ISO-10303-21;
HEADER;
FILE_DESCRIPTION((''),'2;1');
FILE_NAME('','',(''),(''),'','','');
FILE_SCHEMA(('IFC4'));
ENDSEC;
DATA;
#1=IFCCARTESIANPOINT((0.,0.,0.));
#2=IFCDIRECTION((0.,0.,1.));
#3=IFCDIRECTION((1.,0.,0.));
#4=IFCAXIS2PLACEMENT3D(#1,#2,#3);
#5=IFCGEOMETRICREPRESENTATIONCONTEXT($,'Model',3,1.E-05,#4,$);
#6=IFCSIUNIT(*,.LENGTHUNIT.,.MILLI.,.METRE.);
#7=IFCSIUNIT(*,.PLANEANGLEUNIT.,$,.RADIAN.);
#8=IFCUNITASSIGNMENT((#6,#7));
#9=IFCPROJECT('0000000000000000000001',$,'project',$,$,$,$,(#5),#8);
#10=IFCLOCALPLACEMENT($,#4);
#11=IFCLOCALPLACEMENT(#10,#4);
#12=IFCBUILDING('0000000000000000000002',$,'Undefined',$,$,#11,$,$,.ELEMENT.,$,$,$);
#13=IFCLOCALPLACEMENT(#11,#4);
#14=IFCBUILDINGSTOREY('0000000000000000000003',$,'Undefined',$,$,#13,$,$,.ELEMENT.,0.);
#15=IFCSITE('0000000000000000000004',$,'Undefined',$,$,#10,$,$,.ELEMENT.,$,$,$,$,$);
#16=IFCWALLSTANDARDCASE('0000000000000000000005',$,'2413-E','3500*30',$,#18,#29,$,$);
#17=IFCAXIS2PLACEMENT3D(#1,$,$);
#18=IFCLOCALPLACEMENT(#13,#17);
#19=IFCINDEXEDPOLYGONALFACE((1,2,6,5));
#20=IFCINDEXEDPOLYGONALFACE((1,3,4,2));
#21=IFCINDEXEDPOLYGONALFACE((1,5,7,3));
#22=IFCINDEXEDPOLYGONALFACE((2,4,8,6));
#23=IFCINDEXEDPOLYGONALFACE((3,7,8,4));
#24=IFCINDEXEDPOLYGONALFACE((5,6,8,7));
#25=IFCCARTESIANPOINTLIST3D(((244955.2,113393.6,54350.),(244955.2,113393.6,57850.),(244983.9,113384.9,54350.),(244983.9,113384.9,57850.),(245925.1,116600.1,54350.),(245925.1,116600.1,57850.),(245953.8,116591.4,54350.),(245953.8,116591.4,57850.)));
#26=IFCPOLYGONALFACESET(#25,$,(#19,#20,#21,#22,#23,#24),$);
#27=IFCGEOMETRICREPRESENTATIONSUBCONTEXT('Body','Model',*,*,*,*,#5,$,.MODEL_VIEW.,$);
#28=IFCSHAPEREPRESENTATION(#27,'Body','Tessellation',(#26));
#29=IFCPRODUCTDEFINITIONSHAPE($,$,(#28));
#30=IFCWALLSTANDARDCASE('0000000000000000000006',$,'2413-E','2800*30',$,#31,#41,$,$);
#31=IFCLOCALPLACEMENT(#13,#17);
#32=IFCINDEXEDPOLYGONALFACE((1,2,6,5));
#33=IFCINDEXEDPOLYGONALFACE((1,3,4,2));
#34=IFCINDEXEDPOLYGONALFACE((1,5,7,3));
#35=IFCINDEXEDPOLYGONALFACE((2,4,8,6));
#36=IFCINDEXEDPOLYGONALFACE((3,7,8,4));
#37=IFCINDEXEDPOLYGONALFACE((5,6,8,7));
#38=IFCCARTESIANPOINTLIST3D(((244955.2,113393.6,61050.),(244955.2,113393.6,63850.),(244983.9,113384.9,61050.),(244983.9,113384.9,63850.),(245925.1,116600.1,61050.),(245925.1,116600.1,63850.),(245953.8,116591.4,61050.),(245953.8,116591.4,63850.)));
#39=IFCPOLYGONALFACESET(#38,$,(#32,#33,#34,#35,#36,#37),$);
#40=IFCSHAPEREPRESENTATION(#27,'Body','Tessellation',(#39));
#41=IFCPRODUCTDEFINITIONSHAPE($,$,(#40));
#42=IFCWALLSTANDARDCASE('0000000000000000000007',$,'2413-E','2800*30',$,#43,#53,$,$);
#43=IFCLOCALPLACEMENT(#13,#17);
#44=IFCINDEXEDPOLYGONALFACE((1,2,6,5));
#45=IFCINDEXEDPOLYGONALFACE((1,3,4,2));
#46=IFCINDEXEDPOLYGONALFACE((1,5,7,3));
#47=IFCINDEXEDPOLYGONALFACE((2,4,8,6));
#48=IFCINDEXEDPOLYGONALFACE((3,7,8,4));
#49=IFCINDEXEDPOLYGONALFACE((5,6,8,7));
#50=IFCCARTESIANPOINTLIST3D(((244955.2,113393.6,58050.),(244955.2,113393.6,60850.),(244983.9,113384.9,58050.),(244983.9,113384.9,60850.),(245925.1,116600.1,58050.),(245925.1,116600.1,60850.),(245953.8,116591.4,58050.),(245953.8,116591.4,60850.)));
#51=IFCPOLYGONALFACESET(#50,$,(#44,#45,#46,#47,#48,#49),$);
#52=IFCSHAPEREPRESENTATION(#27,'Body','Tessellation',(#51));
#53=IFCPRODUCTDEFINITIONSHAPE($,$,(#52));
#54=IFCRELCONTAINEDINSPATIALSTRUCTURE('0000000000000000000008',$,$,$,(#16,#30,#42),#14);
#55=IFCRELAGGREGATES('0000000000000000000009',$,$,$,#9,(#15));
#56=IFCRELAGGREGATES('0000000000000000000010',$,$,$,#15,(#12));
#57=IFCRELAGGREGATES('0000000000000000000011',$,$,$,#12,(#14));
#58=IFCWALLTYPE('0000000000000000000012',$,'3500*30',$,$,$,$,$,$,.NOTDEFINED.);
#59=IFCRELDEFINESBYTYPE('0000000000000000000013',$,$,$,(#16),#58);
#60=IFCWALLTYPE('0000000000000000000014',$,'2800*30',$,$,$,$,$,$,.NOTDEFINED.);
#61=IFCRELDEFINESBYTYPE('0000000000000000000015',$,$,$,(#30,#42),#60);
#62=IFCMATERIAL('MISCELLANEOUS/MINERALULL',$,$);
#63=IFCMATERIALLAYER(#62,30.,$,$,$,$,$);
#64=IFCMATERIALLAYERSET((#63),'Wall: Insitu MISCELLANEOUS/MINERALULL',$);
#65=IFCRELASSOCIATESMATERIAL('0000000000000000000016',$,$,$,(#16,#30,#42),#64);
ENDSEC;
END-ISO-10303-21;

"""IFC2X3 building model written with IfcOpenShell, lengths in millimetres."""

from ifc_helpers import new_model, si_unit, frame, frame_2d, origin_with_axes, place, context, subcontext, project, spatial, rectangle, extrude, material, layer, layer_set, layer_usage, type_object, element, save


model = new_model("IFC2X3")

# Units and contexts
model_context = context("Model", 3, precision=1e-05, world=origin_with_axes())
body_context = subcontext(model_context, "Body", "Model", "MODEL_VIEW")
ifc_project = project(units=[si_unit("LENGTHUNIT", "METRE", prefix="MILLI"), si_unit("PLANEANGLEUNIT", "RADIAN")], contexts=[model_context])

# Site, building, storey
site_placement = place(None, origin_with_axes())
site = spatial("IfcSite", under=ifc_project, at=site_placement, Name="Undefined", CompositionType="ELEMENT")
building_placement = place(site_placement, origin_with_axes())
building = spatial("IfcBuilding", under=site, at=building_placement, Name="Undefined", CompositionType="ELEMENT")
storey_placement = place(building_placement, origin_with_axes())
storey = spatial("IfcBuildingStorey", under=building, at=storey_placement, Name="Undefined", CompositionType="ELEMENT", Elevation=0.0)

# Walls
ifc_material_1 = material(Name="MISCELLANEOUS/MINERALULL")
ifc_layer_1 = layer(ifc_material_1, 30.0)
ifc_layer_set_1 = layer_set([ifc_layer_1], Name="Wall: Insitu MISCELLANEOUS/MINERALULL")
ifc_layer_usage_1 = layer_usage(ifc_layer_set_1, "AXIS2", "POSITIVE", -15.0)
wall_type_1 = type_object("IfcWallType", Name="3500*30", PredefinedType="NOTDEFINED")
wall_1_placement = place(storey_placement, frame((244969.5, 113389.2, 54350.0), z_axis=(0.0, 0.0, 1.0), x_axis=(0.289536, 0.957167, 0.0)))
element("IfcWallStandardCase", 1, at=wall_1_placement, inside=storey, type_object=wall_type_1, material=ifc_layer_usage_1, Name="2413-E", Description="3500*30", context=body_context, shape_type="SweptSolid", body=[
    extrude(rectangle(XDim=3350.0, YDim=30.0, at=frame_2d((0.0, 1675.0), x_axis=(0.0, -1.0))), frame((0.0, 0.0, 0.0), z_axis=(0.0, 0.0, 1.0), x_axis=(0.0, -1.0, 0.0)), (0.0, 0.0, 1.0), 3500.0),
])
ifc_layer_usage_2 = layer_usage(ifc_layer_set_1, "AXIS2", "POSITIVE", -15.0)
wall_type_2 = type_object("IfcWallType", Name="2800*30", PredefinedType="NOTDEFINED")
wall_2_placement = place(storey_placement, frame((244969.5, 113389.2, 61050.0), z_axis=(0.0, 0.0, 1.0), x_axis=(0.289536, 0.957167, 0.0)))
element("IfcWallStandardCase", 2, at=wall_2_placement, inside=storey, type_object=wall_type_2, material=ifc_layer_usage_2, Name="2413-E", Description="2800*30", context=body_context, shape_type="SweptSolid", body=[
    extrude(rectangle(XDim=3350.0, YDim=30.0, at=frame_2d((0.0, 1675.0), x_axis=(0.0, -1.0))), frame((0.0, 0.0, 0.0), z_axis=(0.0, 0.0, 1.0), x_axis=(0.0, -1.0, 0.0)), (0.0, 0.0, 1.0), 2800.0),
])
ifc_layer_usage_3 = layer_usage(ifc_layer_set_1, "AXIS2", "POSITIVE", -15.0)
wall_3_placement = place(storey_placement, frame((244969.5, 113389.2, 58050.0), z_axis=(0.0, 0.0, 1.0), x_axis=(0.289536, 0.957167, 0.0)))
element("IfcWallStandardCase", 3, at=wall_3_placement, inside=storey, type_object=wall_type_2, material=ifc_layer_usage_3, Name="2413-E", Description="2800*30", context=body_context, shape_type="SweptSolid", body=[
    extrude(rectangle(XDim=3350.0, YDim=30.0, at=frame_2d((0.0, 1675.0), x_axis=(0.0, -1.0))), frame((0.0, 0.0, 0.0), z_axis=(0.0, 0.0, 1.0), x_axis=(0.0, -1.0, 0.0)), (0.0, 0.0, 1.0), 2800.0),
])

save(model, "model.ifc")
